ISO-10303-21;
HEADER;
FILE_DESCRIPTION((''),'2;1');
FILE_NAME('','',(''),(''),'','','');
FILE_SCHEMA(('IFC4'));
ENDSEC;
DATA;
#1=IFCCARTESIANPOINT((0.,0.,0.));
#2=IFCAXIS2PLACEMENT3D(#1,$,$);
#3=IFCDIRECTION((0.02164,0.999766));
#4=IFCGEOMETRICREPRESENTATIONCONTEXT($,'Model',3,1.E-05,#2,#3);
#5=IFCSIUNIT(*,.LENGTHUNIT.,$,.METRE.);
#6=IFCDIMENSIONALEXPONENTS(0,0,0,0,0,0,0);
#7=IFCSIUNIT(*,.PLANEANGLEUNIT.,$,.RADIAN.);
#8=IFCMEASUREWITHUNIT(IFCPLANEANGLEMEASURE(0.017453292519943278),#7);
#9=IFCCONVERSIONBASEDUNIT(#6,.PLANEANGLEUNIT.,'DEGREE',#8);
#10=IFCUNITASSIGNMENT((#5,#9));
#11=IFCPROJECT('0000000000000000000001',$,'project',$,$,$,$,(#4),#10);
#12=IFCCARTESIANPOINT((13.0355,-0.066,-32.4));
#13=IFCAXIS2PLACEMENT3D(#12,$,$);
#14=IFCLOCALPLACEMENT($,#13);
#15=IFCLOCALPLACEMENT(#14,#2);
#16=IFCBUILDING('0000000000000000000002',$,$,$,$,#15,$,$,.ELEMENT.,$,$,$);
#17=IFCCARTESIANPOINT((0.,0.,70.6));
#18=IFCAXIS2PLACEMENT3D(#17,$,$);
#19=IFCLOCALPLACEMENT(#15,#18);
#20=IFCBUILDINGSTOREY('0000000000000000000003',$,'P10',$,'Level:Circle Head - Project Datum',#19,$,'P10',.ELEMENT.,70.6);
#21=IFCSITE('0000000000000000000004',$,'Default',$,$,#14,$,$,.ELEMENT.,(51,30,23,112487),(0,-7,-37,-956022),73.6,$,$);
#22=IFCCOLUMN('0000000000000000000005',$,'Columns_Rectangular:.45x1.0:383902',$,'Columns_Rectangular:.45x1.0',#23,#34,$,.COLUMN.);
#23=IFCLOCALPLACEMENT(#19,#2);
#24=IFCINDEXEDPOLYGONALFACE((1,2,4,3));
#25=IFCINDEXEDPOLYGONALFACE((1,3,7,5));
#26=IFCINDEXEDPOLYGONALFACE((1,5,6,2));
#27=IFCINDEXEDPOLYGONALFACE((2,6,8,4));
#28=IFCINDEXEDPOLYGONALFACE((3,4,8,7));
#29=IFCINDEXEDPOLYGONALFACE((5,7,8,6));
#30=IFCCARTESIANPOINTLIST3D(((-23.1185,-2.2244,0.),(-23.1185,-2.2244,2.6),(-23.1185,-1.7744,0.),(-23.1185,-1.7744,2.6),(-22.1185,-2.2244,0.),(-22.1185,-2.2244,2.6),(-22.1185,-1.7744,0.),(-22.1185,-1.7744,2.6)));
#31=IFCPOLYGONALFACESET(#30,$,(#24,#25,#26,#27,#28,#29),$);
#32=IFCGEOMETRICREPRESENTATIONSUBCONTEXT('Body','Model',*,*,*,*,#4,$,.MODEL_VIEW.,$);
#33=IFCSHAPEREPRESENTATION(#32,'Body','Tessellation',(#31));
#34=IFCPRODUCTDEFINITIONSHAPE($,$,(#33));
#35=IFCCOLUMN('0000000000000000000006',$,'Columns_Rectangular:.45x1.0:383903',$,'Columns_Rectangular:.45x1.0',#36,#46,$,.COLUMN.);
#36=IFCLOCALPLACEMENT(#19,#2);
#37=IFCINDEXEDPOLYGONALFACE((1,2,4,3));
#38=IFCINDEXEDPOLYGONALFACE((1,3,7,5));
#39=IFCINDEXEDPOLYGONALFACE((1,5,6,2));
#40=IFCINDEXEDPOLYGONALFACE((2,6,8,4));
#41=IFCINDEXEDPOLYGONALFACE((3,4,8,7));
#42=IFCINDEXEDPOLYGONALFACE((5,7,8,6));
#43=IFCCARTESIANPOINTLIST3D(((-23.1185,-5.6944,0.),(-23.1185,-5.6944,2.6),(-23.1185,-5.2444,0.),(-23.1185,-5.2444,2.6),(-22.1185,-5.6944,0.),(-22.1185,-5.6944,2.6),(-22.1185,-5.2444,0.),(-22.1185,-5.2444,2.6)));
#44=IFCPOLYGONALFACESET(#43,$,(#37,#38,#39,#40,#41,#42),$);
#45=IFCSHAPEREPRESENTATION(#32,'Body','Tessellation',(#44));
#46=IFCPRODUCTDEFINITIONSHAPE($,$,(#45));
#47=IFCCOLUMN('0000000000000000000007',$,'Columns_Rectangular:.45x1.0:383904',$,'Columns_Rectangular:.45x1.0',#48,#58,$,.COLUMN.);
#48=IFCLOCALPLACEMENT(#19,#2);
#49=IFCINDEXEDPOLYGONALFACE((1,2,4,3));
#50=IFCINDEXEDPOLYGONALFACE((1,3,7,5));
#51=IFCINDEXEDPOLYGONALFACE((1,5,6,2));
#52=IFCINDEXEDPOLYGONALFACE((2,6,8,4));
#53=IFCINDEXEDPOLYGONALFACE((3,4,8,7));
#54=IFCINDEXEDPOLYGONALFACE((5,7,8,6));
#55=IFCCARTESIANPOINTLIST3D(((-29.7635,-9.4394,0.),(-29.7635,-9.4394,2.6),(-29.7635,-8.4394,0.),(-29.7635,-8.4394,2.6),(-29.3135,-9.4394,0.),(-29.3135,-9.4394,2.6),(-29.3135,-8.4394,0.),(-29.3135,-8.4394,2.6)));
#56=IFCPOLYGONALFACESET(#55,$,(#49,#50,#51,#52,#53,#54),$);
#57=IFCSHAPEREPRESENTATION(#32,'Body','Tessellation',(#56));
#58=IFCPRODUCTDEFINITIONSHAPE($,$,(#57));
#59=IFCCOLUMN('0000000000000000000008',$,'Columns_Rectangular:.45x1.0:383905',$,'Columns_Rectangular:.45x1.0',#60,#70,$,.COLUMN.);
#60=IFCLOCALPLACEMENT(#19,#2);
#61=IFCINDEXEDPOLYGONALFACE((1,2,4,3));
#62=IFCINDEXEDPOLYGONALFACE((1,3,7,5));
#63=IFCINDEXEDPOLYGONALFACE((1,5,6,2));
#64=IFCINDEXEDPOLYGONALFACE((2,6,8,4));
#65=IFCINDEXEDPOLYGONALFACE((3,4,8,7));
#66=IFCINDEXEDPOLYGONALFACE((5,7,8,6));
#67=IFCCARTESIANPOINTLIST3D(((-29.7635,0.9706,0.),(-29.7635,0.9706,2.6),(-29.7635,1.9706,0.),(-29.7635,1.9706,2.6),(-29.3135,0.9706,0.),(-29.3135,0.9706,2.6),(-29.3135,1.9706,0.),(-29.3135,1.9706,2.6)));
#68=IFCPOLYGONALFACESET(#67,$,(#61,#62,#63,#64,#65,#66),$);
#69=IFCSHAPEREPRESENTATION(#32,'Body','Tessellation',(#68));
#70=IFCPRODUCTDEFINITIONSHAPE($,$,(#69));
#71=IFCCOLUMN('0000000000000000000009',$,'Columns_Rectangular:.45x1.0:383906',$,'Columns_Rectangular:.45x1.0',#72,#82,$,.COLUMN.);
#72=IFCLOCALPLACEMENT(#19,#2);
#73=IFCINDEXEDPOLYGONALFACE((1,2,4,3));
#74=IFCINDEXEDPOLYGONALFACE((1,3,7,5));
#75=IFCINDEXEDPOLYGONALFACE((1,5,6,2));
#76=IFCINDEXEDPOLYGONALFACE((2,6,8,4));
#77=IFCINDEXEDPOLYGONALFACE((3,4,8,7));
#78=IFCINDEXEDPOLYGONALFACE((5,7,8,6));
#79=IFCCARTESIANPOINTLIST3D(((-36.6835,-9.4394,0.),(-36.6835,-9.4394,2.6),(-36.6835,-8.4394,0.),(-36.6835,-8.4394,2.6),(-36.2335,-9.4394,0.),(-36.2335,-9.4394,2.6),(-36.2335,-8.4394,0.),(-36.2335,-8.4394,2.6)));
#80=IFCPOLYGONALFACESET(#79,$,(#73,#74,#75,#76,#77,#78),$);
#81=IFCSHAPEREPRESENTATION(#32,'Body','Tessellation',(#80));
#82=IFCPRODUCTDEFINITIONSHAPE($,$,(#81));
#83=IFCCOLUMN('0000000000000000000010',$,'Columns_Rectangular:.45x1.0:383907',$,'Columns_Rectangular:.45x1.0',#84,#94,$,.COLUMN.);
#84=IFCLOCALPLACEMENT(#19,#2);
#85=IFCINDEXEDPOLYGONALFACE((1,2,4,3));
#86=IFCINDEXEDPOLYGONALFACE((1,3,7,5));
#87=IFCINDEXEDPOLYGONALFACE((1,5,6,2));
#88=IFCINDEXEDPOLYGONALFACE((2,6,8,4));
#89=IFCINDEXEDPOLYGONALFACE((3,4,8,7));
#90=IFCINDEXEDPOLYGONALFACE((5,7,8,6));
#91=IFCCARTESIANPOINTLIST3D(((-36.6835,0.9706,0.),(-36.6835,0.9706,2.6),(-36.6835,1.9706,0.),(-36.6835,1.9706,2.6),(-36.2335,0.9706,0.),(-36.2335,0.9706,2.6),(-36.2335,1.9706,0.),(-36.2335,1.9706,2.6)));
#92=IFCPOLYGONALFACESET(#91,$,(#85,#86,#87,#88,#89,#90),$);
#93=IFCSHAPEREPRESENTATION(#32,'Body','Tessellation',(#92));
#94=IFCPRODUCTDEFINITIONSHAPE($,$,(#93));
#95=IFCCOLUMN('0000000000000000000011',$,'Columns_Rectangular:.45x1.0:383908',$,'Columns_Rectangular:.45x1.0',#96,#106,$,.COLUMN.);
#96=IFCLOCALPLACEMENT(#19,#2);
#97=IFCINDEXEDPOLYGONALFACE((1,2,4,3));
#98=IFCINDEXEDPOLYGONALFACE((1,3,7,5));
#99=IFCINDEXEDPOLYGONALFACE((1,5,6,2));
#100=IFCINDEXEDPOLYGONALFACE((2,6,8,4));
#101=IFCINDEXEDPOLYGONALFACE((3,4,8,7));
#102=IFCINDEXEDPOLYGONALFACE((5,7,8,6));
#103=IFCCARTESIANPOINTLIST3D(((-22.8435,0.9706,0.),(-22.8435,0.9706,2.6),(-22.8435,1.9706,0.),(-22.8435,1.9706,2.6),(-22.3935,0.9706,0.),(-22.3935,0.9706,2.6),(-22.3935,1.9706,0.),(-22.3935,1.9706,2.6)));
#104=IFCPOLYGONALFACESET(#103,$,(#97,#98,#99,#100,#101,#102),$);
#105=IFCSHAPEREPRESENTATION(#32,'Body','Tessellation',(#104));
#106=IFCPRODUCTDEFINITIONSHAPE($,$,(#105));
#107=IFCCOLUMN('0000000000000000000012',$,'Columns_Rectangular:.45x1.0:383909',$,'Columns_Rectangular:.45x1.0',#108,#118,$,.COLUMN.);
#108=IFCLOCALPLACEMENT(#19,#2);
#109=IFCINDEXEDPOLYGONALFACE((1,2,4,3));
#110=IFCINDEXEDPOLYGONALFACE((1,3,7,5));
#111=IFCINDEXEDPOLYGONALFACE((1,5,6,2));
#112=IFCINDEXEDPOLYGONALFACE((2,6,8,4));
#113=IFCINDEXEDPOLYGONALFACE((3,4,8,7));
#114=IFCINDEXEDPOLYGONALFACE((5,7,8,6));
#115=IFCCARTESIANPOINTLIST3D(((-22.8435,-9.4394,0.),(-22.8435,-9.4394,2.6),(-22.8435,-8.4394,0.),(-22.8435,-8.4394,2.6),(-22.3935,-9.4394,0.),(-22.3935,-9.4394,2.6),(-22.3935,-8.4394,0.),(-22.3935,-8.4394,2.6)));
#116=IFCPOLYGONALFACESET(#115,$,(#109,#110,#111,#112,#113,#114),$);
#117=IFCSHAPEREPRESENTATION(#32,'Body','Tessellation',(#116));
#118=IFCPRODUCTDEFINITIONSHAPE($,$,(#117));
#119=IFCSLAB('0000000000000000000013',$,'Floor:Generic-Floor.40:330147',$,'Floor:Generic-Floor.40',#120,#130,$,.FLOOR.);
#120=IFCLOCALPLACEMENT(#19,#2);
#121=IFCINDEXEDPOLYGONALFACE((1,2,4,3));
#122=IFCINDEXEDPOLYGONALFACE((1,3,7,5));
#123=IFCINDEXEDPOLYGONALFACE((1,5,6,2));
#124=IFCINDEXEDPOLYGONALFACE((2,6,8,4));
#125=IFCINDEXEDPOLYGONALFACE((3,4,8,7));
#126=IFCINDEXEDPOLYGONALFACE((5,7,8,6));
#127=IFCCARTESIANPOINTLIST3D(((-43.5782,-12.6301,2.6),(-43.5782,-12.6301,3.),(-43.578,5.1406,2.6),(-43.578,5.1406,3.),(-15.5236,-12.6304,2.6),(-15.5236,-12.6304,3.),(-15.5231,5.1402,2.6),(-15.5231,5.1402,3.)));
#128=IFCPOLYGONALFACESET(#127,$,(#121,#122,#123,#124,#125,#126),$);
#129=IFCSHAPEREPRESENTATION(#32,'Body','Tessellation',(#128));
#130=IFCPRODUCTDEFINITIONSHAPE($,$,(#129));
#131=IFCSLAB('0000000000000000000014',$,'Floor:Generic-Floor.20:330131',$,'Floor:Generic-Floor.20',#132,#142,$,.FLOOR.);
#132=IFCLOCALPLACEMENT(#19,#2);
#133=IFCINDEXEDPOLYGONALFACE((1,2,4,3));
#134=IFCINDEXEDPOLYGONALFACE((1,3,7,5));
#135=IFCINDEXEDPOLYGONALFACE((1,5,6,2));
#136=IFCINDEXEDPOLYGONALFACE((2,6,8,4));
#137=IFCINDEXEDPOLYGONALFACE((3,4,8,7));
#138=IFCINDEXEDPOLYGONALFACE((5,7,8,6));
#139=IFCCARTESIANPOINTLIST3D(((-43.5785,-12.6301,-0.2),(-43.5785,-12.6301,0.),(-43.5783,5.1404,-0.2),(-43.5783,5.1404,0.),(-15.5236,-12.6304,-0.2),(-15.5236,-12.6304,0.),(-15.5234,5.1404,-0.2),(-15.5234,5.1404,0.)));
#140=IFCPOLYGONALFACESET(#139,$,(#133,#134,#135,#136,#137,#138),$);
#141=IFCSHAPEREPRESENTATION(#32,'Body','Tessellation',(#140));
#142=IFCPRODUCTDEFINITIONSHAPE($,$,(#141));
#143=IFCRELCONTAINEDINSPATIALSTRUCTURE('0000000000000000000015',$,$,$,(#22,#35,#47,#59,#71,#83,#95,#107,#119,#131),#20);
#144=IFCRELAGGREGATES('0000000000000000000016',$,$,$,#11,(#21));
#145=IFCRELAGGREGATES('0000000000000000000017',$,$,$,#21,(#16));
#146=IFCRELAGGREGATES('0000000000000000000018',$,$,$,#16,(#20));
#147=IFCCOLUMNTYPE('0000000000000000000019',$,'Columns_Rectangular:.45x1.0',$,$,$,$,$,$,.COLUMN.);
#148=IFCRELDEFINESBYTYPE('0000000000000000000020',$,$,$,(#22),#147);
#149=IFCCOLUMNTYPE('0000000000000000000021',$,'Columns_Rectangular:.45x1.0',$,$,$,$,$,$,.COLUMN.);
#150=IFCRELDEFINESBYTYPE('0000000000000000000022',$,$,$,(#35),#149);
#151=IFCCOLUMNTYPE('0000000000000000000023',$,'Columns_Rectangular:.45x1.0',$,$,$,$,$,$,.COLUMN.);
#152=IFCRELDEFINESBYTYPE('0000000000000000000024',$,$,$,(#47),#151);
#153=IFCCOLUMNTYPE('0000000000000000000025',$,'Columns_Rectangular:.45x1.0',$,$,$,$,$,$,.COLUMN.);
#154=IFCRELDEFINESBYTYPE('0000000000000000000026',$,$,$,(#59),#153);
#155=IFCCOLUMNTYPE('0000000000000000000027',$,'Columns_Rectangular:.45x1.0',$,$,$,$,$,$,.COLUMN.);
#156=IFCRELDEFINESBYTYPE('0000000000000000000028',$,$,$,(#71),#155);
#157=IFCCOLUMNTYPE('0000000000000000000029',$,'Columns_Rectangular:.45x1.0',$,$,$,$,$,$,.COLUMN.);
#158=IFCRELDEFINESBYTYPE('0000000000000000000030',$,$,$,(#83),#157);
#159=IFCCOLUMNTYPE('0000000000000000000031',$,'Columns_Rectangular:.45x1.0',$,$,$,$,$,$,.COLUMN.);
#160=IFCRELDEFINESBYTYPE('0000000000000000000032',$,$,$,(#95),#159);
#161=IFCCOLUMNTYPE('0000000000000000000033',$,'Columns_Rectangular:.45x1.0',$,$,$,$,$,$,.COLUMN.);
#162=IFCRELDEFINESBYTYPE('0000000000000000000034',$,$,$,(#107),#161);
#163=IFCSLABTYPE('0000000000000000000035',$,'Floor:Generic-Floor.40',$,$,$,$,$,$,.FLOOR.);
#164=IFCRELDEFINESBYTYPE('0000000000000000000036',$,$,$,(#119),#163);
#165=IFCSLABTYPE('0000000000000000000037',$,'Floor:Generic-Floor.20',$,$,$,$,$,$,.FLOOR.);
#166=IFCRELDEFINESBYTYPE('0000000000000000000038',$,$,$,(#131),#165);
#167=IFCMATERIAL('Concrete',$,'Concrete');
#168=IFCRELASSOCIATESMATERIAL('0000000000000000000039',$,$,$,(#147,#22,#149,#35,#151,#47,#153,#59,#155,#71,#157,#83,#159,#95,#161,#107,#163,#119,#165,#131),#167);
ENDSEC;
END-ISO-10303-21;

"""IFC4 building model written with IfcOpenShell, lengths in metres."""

from ifc_helpers import new_model, entity, si_unit, converted_unit, direction, frame, origin, place, context, subcontext, project, spatial, indexed_curve, outline, extrude, source, transform, mapped, material, type_object, type_shapes, element, save


model = new_model("IFC4")

# Units and contexts
model_context = context("Model", 3, precision=1e-05, world=origin(), true_north=direction((0.02164, 0.999766)))
body_context = subcontext(model_context, "Body", "Model", "MODEL_VIEW")
ifc_project = project(units=[si_unit("LENGTHUNIT", "METRE"), converted_unit("PLANEANGLEUNIT", "DEGREE", entity("IfcPlaneAngleMeasure", 0.017453292519943278), si_unit("PLANEANGLEUNIT", "RADIAN"), dimensions=[0, 0, 0, 0, 0, 0, 0])], contexts=[model_context])

# Site, building, storey
site_placement = place(None, frame((13.0355, -0.066, -32.4)))
site = spatial("IfcSite", under=ifc_project, at=site_placement, Name="Default", CompositionType="ELEMENT", RefLatitude=(51, 30, 23, 112487), RefLongitude=(0, -7, -37, -956022), RefElevation=73.6)
building_placement = place(site_placement, origin())
building = spatial("IfcBuilding", under=site, at=building_placement, CompositionType="ELEMENT")
storey_placement = place(building_placement, frame((0.0, 0.0, 70.6)))
storey = spatial("IfcBuildingStorey", under=building, at=storey_placement, Name="P10", ObjectType="Level:Circle Head - Project Datum", LongName="P10", CompositionType="ELEMENT", Elevation=70.6)

# Columns
ifc_material = material(Name="Concrete", Category="Concrete")
column_type_1 = type_object("IfcColumnType", Name="Columns_Rectangular:.45x1.0", PredefinedType="COLUMN", material=ifc_material)
shared_shape_1 = source(origin(), body_context, "Body", "SweptSolid", [
    extrude(outline(indexed_curve([(-1.3, -0.225), (1.3, -0.225), (1.3, 0.225), (-1.3, 0.225), (-1.3, -0.225)], self_intersect=False)), frame((-23.1185, -1.9994, 71.9), z_axis=(1.0, 0.0, 0.0), x_axis=(0.0, 0.0, 1.0)), (0.0, 0.0, 1.0), 1.0),
])
type_shapes(column_type_1, [shared_shape_1])
column_1_placement = place(storey_placement, frame((0.0, 0.0, -70.6)))
element("IfcColumn", 1, at=column_1_placement, inside=storey, type_object=column_type_1, material=ifc_material, Name="Columns_Rectangular:.45x1.0:383902", ObjectType="Columns_Rectangular:.45x1.0", PredefinedType="COLUMN", context=body_context, shape_type="MappedRepresentation", body=[
    mapped(shared_shape_1, transform((0.0, 0.0, 0.0), scale=1.0)),
])
column_type_2 = type_object("IfcColumnType", Name="Columns_Rectangular:.45x1.0", PredefinedType="COLUMN", material=ifc_material)
shared_shape_2 = source(origin(), body_context, "Body", "SweptSolid", [
    extrude(outline(indexed_curve([(-1.3, -0.225), (1.3, -0.225), (1.3, 0.225), (-1.3, 0.225), (-1.3, -0.225)], self_intersect=False)), frame((-23.1185, -5.4694, 71.9), z_axis=(1.0, 0.0, 0.0), x_axis=(0.0, 0.0, 1.0)), (0.0, 0.0, 1.0), 1.0),
])
type_shapes(column_type_2, [shared_shape_2])
column_2_placement = place(storey_placement, frame((0.0, 0.0, -70.6)))
element("IfcColumn", 2, at=column_2_placement, inside=storey, type_object=column_type_2, material=ifc_material, Name="Columns_Rectangular:.45x1.0:383903", ObjectType="Columns_Rectangular:.45x1.0", PredefinedType="COLUMN", context=body_context, shape_type="MappedRepresentation", body=[
    mapped(shared_shape_2, transform((0.0, 0.0, 0.0), scale=1.0)),
])
column_type_3 = type_object("IfcColumnType", Name="Columns_Rectangular:.45x1.0", PredefinedType="COLUMN", material=ifc_material)
shared_shape_3 = source(origin(), body_context, "Body", "SweptSolid", [
    extrude(outline(indexed_curve([(-1.3, -0.5), (1.3, -0.5), (1.3, 0.5), (-1.3, 0.5), (-1.3, -0.5)], self_intersect=False)), frame((-29.7635, -8.9394, 71.9), z_axis=(1.0, 0.0, 0.0), x_axis=(0.0, 0.0, 1.0)), (0.0, 0.0, 1.0), 0.45),
])
type_shapes(column_type_3, [shared_shape_3])
column_3_placement = place(storey_placement, frame((0.0, 0.0, -70.6)))
element("IfcColumn", 3, at=column_3_placement, inside=storey, type_object=column_type_3, material=ifc_material, Name="Columns_Rectangular:.45x1.0:383904", ObjectType="Columns_Rectangular:.45x1.0", PredefinedType="COLUMN", context=body_context, shape_type="MappedRepresentation", body=[
    mapped(shared_shape_3, transform((0.0, 0.0, 0.0), scale=1.0)),
])
column_type_4 = type_object("IfcColumnType", Name="Columns_Rectangular:.45x1.0", PredefinedType="COLUMN", material=ifc_material)
shared_shape_4 = source(origin(), body_context, "Body", "SweptSolid", [
    extrude(outline(indexed_curve([(-1.3, -0.5), (1.3, -0.5), (1.3, 0.5), (-1.3, 0.5), (-1.3, -0.5)], self_intersect=False)), frame((-29.7635, 1.4706, 71.9), z_axis=(1.0, 0.0, 0.0), x_axis=(0.0, 0.0, 1.0)), (0.0, 0.0, 1.0), 0.45),
])
type_shapes(column_type_4, [shared_shape_4])
column_4_placement = place(storey_placement, frame((0.0, 0.0, -70.6)))
element("IfcColumn", 4, at=column_4_placement, inside=storey, type_object=column_type_4, material=ifc_material, Name="Columns_Rectangular:.45x1.0:383905", ObjectType="Columns_Rectangular:.45x1.0", PredefinedType="COLUMN", context=body_context, shape_type="MappedRepresentation", body=[
    mapped(shared_shape_4, transform((0.0, 0.0, 0.0), scale=1.0)),
])
column_type_5 = type_object("IfcColumnType", Name="Columns_Rectangular:.45x1.0", PredefinedType="COLUMN", material=ifc_material)
shared_shape_5 = source(origin(), body_context, "Body", "SweptSolid", [
    extrude(outline(indexed_curve([(-1.3, -0.5), (1.3, -0.5), (1.3, 0.5), (-1.3, 0.5), (-1.3, -0.5)], self_intersect=False)), frame((-36.6835, -8.9394, 71.9), z_axis=(1.0, 0.0, 0.0), x_axis=(0.0, 0.0, 1.0)), (0.0, 0.0, 1.0), 0.45),
])
type_shapes(column_type_5, [shared_shape_5])
column_5_placement = place(storey_placement, frame((0.0, 0.0, -70.6)))
element("IfcColumn", 5, at=column_5_placement, inside=storey, type_object=column_type_5, material=ifc_material, Name="Columns_Rectangular:.45x1.0:383906", ObjectType="Columns_Rectangular:.45x1.0", PredefinedType="COLUMN", context=body_context, shape_type="MappedRepresentation", body=[
    mapped(shared_shape_5, transform((0.0, 0.0, 0.0), scale=1.0)),
])
column_type_6 = type_object("IfcColumnType", Name="Columns_Rectangular:.45x1.0", PredefinedType="COLUMN", material=ifc_material)
shared_shape_6 = source(origin(), body_context, "Body", "SweptSolid", [
    extrude(outline(indexed_curve([(-1.3, -0.5), (1.3, -0.5), (1.3, 0.5), (-1.3, 0.5), (-1.3, -0.5)], self_intersect=False)), frame((-36.6835, 1.4706, 71.9), z_axis=(1.0, 0.0, 0.0), x_axis=(0.0, 0.0, 1.0)), (0.0, 0.0, 1.0), 0.45),
])
type_shapes(column_type_6, [shared_shape_6])
column_6_placement = place(storey_placement, frame((0.0, 0.0, -70.6)))
element("IfcColumn", 6, at=column_6_placement, inside=storey, type_object=column_type_6, material=ifc_material, Name="Columns_Rectangular:.45x1.0:383907", ObjectType="Columns_Rectangular:.45x1.0", PredefinedType="COLUMN", context=body_context, shape_type="MappedRepresentation", body=[
    mapped(shared_shape_6, transform((0.0, 0.0, 0.0), scale=1.0)),
])
column_type_7 = type_object("IfcColumnType", Name="Columns_Rectangular:.45x1.0", PredefinedType="COLUMN", material=ifc_material)
shared_shape_7 = source(origin(), body_context, "Body", "SweptSolid", [
    extrude(outline(indexed_curve([(-1.3, -0.5), (1.3, -0.5), (1.3, 0.5), (-1.3, 0.5), (-1.3, -0.5)], self_intersect=False)), frame((-22.8435, 1.4706, 71.9), z_axis=(1.0, 0.0, 0.0), x_axis=(0.0, 0.0, 1.0)), (0.0, 0.0, 1.0), 0.45),
])
type_shapes(column_type_7, [shared_shape_7])
column_7_placement = place(storey_placement, frame((0.0, 0.0, -70.6)))
element("IfcColumn", 7, at=column_7_placement, inside=storey, type_object=column_type_7, material=ifc_material, Name="Columns_Rectangular:.45x1.0:383908", ObjectType="Columns_Rectangular:.45x1.0", PredefinedType="COLUMN", context=body_context, shape_type="MappedRepresentation", body=[
    mapped(shared_shape_7, transform((0.0, 0.0, 0.0), scale=1.0)),
])
column_type_8 = type_object("IfcColumnType", Name="Columns_Rectangular:.45x1.0", PredefinedType="COLUMN", material=ifc_material)
shared_shape_8 = source(origin(), body_context, "Body", "SweptSolid", [
    extrude(outline(indexed_curve([(-1.3, -0.5), (1.3, -0.5), (1.3, 0.5), (-1.3, 0.5), (-1.3, -0.5)], self_intersect=False)), frame((-22.8435, -8.9394, 71.9), z_axis=(1.0, 0.0, 0.0), x_axis=(0.0, 0.0, 1.0)), (0.0, 0.0, 1.0), 0.45),
])
type_shapes(column_type_8, [shared_shape_8])
column_8_placement = place(storey_placement, frame((0.0, 0.0, -70.6)))
element("IfcColumn", 8, at=column_8_placement, inside=storey, type_object=column_type_8, material=ifc_material, Name="Columns_Rectangular:.45x1.0:383909", ObjectType="Columns_Rectangular:.45x1.0", PredefinedType="COLUMN", context=body_context, shape_type="MappedRepresentation", body=[
    mapped(shared_shape_8, transform((0.0, 0.0, 0.0), scale=1.0)),
])

# Slabs
slab_type_1 = type_object("IfcSlabType", Name="Floor:Generic-Floor.40", PredefinedType="FLOOR", material=ifc_material)
slab_1_placement = place(storey_placement, origin())
element("IfcSlab", 9, at=slab_1_placement, inside=storey, type_object=slab_type_1, material=ifc_material, Name="Floor:Generic-Floor.40:330147", ObjectType="Floor:Generic-Floor.40", PredefinedType="FLOOR", context=body_context, shape_type="SweptSolid", body=[
    extrude(outline(indexed_curve([(-14.0274, -8.8853), (14.0275, -8.8853), (14.0273, 8.8853), (-14.0273, 8.8854), (-14.0274, -8.8853)], self_intersect=False)), frame((-29.5507, -3.7449, 3.0), z_axis=(0.0, 0.0, -1.0), x_axis=(1.0, -0.000016, 0.0)), (0.0, 0.0, 1.0), 0.4),
])
slab_type_2 = type_object("IfcSlabType", Name="Floor:Generic-Floor.20", PredefinedType="FLOOR", material=ifc_material)
slab_2_placement = place(storey_placement, origin())
element("IfcSlab", 10, at=slab_2_placement, inside=storey, type_object=slab_type_2, material=ifc_material, Name="Floor:Generic-Floor.20:330131", ObjectType="Floor:Generic-Floor.20", PredefinedType="FLOOR", context=body_context, shape_type="SweptSolid", body=[
    extrude(outline(indexed_curve([(-14.0274, -8.8853), (14.0275, -8.8853), (14.0274, 8.8855), (-14.0275, 8.8852), (-14.0274, -8.8853)], self_intersect=False)), frame((-29.5509, -3.7449, 0.0), z_axis=(0.0, 0.0, -1.0), x_axis=(1.0, 0.0, 0.0)), (0.0, 0.0, 1.0), 0.2),
])

save(model, "model.ifc")
